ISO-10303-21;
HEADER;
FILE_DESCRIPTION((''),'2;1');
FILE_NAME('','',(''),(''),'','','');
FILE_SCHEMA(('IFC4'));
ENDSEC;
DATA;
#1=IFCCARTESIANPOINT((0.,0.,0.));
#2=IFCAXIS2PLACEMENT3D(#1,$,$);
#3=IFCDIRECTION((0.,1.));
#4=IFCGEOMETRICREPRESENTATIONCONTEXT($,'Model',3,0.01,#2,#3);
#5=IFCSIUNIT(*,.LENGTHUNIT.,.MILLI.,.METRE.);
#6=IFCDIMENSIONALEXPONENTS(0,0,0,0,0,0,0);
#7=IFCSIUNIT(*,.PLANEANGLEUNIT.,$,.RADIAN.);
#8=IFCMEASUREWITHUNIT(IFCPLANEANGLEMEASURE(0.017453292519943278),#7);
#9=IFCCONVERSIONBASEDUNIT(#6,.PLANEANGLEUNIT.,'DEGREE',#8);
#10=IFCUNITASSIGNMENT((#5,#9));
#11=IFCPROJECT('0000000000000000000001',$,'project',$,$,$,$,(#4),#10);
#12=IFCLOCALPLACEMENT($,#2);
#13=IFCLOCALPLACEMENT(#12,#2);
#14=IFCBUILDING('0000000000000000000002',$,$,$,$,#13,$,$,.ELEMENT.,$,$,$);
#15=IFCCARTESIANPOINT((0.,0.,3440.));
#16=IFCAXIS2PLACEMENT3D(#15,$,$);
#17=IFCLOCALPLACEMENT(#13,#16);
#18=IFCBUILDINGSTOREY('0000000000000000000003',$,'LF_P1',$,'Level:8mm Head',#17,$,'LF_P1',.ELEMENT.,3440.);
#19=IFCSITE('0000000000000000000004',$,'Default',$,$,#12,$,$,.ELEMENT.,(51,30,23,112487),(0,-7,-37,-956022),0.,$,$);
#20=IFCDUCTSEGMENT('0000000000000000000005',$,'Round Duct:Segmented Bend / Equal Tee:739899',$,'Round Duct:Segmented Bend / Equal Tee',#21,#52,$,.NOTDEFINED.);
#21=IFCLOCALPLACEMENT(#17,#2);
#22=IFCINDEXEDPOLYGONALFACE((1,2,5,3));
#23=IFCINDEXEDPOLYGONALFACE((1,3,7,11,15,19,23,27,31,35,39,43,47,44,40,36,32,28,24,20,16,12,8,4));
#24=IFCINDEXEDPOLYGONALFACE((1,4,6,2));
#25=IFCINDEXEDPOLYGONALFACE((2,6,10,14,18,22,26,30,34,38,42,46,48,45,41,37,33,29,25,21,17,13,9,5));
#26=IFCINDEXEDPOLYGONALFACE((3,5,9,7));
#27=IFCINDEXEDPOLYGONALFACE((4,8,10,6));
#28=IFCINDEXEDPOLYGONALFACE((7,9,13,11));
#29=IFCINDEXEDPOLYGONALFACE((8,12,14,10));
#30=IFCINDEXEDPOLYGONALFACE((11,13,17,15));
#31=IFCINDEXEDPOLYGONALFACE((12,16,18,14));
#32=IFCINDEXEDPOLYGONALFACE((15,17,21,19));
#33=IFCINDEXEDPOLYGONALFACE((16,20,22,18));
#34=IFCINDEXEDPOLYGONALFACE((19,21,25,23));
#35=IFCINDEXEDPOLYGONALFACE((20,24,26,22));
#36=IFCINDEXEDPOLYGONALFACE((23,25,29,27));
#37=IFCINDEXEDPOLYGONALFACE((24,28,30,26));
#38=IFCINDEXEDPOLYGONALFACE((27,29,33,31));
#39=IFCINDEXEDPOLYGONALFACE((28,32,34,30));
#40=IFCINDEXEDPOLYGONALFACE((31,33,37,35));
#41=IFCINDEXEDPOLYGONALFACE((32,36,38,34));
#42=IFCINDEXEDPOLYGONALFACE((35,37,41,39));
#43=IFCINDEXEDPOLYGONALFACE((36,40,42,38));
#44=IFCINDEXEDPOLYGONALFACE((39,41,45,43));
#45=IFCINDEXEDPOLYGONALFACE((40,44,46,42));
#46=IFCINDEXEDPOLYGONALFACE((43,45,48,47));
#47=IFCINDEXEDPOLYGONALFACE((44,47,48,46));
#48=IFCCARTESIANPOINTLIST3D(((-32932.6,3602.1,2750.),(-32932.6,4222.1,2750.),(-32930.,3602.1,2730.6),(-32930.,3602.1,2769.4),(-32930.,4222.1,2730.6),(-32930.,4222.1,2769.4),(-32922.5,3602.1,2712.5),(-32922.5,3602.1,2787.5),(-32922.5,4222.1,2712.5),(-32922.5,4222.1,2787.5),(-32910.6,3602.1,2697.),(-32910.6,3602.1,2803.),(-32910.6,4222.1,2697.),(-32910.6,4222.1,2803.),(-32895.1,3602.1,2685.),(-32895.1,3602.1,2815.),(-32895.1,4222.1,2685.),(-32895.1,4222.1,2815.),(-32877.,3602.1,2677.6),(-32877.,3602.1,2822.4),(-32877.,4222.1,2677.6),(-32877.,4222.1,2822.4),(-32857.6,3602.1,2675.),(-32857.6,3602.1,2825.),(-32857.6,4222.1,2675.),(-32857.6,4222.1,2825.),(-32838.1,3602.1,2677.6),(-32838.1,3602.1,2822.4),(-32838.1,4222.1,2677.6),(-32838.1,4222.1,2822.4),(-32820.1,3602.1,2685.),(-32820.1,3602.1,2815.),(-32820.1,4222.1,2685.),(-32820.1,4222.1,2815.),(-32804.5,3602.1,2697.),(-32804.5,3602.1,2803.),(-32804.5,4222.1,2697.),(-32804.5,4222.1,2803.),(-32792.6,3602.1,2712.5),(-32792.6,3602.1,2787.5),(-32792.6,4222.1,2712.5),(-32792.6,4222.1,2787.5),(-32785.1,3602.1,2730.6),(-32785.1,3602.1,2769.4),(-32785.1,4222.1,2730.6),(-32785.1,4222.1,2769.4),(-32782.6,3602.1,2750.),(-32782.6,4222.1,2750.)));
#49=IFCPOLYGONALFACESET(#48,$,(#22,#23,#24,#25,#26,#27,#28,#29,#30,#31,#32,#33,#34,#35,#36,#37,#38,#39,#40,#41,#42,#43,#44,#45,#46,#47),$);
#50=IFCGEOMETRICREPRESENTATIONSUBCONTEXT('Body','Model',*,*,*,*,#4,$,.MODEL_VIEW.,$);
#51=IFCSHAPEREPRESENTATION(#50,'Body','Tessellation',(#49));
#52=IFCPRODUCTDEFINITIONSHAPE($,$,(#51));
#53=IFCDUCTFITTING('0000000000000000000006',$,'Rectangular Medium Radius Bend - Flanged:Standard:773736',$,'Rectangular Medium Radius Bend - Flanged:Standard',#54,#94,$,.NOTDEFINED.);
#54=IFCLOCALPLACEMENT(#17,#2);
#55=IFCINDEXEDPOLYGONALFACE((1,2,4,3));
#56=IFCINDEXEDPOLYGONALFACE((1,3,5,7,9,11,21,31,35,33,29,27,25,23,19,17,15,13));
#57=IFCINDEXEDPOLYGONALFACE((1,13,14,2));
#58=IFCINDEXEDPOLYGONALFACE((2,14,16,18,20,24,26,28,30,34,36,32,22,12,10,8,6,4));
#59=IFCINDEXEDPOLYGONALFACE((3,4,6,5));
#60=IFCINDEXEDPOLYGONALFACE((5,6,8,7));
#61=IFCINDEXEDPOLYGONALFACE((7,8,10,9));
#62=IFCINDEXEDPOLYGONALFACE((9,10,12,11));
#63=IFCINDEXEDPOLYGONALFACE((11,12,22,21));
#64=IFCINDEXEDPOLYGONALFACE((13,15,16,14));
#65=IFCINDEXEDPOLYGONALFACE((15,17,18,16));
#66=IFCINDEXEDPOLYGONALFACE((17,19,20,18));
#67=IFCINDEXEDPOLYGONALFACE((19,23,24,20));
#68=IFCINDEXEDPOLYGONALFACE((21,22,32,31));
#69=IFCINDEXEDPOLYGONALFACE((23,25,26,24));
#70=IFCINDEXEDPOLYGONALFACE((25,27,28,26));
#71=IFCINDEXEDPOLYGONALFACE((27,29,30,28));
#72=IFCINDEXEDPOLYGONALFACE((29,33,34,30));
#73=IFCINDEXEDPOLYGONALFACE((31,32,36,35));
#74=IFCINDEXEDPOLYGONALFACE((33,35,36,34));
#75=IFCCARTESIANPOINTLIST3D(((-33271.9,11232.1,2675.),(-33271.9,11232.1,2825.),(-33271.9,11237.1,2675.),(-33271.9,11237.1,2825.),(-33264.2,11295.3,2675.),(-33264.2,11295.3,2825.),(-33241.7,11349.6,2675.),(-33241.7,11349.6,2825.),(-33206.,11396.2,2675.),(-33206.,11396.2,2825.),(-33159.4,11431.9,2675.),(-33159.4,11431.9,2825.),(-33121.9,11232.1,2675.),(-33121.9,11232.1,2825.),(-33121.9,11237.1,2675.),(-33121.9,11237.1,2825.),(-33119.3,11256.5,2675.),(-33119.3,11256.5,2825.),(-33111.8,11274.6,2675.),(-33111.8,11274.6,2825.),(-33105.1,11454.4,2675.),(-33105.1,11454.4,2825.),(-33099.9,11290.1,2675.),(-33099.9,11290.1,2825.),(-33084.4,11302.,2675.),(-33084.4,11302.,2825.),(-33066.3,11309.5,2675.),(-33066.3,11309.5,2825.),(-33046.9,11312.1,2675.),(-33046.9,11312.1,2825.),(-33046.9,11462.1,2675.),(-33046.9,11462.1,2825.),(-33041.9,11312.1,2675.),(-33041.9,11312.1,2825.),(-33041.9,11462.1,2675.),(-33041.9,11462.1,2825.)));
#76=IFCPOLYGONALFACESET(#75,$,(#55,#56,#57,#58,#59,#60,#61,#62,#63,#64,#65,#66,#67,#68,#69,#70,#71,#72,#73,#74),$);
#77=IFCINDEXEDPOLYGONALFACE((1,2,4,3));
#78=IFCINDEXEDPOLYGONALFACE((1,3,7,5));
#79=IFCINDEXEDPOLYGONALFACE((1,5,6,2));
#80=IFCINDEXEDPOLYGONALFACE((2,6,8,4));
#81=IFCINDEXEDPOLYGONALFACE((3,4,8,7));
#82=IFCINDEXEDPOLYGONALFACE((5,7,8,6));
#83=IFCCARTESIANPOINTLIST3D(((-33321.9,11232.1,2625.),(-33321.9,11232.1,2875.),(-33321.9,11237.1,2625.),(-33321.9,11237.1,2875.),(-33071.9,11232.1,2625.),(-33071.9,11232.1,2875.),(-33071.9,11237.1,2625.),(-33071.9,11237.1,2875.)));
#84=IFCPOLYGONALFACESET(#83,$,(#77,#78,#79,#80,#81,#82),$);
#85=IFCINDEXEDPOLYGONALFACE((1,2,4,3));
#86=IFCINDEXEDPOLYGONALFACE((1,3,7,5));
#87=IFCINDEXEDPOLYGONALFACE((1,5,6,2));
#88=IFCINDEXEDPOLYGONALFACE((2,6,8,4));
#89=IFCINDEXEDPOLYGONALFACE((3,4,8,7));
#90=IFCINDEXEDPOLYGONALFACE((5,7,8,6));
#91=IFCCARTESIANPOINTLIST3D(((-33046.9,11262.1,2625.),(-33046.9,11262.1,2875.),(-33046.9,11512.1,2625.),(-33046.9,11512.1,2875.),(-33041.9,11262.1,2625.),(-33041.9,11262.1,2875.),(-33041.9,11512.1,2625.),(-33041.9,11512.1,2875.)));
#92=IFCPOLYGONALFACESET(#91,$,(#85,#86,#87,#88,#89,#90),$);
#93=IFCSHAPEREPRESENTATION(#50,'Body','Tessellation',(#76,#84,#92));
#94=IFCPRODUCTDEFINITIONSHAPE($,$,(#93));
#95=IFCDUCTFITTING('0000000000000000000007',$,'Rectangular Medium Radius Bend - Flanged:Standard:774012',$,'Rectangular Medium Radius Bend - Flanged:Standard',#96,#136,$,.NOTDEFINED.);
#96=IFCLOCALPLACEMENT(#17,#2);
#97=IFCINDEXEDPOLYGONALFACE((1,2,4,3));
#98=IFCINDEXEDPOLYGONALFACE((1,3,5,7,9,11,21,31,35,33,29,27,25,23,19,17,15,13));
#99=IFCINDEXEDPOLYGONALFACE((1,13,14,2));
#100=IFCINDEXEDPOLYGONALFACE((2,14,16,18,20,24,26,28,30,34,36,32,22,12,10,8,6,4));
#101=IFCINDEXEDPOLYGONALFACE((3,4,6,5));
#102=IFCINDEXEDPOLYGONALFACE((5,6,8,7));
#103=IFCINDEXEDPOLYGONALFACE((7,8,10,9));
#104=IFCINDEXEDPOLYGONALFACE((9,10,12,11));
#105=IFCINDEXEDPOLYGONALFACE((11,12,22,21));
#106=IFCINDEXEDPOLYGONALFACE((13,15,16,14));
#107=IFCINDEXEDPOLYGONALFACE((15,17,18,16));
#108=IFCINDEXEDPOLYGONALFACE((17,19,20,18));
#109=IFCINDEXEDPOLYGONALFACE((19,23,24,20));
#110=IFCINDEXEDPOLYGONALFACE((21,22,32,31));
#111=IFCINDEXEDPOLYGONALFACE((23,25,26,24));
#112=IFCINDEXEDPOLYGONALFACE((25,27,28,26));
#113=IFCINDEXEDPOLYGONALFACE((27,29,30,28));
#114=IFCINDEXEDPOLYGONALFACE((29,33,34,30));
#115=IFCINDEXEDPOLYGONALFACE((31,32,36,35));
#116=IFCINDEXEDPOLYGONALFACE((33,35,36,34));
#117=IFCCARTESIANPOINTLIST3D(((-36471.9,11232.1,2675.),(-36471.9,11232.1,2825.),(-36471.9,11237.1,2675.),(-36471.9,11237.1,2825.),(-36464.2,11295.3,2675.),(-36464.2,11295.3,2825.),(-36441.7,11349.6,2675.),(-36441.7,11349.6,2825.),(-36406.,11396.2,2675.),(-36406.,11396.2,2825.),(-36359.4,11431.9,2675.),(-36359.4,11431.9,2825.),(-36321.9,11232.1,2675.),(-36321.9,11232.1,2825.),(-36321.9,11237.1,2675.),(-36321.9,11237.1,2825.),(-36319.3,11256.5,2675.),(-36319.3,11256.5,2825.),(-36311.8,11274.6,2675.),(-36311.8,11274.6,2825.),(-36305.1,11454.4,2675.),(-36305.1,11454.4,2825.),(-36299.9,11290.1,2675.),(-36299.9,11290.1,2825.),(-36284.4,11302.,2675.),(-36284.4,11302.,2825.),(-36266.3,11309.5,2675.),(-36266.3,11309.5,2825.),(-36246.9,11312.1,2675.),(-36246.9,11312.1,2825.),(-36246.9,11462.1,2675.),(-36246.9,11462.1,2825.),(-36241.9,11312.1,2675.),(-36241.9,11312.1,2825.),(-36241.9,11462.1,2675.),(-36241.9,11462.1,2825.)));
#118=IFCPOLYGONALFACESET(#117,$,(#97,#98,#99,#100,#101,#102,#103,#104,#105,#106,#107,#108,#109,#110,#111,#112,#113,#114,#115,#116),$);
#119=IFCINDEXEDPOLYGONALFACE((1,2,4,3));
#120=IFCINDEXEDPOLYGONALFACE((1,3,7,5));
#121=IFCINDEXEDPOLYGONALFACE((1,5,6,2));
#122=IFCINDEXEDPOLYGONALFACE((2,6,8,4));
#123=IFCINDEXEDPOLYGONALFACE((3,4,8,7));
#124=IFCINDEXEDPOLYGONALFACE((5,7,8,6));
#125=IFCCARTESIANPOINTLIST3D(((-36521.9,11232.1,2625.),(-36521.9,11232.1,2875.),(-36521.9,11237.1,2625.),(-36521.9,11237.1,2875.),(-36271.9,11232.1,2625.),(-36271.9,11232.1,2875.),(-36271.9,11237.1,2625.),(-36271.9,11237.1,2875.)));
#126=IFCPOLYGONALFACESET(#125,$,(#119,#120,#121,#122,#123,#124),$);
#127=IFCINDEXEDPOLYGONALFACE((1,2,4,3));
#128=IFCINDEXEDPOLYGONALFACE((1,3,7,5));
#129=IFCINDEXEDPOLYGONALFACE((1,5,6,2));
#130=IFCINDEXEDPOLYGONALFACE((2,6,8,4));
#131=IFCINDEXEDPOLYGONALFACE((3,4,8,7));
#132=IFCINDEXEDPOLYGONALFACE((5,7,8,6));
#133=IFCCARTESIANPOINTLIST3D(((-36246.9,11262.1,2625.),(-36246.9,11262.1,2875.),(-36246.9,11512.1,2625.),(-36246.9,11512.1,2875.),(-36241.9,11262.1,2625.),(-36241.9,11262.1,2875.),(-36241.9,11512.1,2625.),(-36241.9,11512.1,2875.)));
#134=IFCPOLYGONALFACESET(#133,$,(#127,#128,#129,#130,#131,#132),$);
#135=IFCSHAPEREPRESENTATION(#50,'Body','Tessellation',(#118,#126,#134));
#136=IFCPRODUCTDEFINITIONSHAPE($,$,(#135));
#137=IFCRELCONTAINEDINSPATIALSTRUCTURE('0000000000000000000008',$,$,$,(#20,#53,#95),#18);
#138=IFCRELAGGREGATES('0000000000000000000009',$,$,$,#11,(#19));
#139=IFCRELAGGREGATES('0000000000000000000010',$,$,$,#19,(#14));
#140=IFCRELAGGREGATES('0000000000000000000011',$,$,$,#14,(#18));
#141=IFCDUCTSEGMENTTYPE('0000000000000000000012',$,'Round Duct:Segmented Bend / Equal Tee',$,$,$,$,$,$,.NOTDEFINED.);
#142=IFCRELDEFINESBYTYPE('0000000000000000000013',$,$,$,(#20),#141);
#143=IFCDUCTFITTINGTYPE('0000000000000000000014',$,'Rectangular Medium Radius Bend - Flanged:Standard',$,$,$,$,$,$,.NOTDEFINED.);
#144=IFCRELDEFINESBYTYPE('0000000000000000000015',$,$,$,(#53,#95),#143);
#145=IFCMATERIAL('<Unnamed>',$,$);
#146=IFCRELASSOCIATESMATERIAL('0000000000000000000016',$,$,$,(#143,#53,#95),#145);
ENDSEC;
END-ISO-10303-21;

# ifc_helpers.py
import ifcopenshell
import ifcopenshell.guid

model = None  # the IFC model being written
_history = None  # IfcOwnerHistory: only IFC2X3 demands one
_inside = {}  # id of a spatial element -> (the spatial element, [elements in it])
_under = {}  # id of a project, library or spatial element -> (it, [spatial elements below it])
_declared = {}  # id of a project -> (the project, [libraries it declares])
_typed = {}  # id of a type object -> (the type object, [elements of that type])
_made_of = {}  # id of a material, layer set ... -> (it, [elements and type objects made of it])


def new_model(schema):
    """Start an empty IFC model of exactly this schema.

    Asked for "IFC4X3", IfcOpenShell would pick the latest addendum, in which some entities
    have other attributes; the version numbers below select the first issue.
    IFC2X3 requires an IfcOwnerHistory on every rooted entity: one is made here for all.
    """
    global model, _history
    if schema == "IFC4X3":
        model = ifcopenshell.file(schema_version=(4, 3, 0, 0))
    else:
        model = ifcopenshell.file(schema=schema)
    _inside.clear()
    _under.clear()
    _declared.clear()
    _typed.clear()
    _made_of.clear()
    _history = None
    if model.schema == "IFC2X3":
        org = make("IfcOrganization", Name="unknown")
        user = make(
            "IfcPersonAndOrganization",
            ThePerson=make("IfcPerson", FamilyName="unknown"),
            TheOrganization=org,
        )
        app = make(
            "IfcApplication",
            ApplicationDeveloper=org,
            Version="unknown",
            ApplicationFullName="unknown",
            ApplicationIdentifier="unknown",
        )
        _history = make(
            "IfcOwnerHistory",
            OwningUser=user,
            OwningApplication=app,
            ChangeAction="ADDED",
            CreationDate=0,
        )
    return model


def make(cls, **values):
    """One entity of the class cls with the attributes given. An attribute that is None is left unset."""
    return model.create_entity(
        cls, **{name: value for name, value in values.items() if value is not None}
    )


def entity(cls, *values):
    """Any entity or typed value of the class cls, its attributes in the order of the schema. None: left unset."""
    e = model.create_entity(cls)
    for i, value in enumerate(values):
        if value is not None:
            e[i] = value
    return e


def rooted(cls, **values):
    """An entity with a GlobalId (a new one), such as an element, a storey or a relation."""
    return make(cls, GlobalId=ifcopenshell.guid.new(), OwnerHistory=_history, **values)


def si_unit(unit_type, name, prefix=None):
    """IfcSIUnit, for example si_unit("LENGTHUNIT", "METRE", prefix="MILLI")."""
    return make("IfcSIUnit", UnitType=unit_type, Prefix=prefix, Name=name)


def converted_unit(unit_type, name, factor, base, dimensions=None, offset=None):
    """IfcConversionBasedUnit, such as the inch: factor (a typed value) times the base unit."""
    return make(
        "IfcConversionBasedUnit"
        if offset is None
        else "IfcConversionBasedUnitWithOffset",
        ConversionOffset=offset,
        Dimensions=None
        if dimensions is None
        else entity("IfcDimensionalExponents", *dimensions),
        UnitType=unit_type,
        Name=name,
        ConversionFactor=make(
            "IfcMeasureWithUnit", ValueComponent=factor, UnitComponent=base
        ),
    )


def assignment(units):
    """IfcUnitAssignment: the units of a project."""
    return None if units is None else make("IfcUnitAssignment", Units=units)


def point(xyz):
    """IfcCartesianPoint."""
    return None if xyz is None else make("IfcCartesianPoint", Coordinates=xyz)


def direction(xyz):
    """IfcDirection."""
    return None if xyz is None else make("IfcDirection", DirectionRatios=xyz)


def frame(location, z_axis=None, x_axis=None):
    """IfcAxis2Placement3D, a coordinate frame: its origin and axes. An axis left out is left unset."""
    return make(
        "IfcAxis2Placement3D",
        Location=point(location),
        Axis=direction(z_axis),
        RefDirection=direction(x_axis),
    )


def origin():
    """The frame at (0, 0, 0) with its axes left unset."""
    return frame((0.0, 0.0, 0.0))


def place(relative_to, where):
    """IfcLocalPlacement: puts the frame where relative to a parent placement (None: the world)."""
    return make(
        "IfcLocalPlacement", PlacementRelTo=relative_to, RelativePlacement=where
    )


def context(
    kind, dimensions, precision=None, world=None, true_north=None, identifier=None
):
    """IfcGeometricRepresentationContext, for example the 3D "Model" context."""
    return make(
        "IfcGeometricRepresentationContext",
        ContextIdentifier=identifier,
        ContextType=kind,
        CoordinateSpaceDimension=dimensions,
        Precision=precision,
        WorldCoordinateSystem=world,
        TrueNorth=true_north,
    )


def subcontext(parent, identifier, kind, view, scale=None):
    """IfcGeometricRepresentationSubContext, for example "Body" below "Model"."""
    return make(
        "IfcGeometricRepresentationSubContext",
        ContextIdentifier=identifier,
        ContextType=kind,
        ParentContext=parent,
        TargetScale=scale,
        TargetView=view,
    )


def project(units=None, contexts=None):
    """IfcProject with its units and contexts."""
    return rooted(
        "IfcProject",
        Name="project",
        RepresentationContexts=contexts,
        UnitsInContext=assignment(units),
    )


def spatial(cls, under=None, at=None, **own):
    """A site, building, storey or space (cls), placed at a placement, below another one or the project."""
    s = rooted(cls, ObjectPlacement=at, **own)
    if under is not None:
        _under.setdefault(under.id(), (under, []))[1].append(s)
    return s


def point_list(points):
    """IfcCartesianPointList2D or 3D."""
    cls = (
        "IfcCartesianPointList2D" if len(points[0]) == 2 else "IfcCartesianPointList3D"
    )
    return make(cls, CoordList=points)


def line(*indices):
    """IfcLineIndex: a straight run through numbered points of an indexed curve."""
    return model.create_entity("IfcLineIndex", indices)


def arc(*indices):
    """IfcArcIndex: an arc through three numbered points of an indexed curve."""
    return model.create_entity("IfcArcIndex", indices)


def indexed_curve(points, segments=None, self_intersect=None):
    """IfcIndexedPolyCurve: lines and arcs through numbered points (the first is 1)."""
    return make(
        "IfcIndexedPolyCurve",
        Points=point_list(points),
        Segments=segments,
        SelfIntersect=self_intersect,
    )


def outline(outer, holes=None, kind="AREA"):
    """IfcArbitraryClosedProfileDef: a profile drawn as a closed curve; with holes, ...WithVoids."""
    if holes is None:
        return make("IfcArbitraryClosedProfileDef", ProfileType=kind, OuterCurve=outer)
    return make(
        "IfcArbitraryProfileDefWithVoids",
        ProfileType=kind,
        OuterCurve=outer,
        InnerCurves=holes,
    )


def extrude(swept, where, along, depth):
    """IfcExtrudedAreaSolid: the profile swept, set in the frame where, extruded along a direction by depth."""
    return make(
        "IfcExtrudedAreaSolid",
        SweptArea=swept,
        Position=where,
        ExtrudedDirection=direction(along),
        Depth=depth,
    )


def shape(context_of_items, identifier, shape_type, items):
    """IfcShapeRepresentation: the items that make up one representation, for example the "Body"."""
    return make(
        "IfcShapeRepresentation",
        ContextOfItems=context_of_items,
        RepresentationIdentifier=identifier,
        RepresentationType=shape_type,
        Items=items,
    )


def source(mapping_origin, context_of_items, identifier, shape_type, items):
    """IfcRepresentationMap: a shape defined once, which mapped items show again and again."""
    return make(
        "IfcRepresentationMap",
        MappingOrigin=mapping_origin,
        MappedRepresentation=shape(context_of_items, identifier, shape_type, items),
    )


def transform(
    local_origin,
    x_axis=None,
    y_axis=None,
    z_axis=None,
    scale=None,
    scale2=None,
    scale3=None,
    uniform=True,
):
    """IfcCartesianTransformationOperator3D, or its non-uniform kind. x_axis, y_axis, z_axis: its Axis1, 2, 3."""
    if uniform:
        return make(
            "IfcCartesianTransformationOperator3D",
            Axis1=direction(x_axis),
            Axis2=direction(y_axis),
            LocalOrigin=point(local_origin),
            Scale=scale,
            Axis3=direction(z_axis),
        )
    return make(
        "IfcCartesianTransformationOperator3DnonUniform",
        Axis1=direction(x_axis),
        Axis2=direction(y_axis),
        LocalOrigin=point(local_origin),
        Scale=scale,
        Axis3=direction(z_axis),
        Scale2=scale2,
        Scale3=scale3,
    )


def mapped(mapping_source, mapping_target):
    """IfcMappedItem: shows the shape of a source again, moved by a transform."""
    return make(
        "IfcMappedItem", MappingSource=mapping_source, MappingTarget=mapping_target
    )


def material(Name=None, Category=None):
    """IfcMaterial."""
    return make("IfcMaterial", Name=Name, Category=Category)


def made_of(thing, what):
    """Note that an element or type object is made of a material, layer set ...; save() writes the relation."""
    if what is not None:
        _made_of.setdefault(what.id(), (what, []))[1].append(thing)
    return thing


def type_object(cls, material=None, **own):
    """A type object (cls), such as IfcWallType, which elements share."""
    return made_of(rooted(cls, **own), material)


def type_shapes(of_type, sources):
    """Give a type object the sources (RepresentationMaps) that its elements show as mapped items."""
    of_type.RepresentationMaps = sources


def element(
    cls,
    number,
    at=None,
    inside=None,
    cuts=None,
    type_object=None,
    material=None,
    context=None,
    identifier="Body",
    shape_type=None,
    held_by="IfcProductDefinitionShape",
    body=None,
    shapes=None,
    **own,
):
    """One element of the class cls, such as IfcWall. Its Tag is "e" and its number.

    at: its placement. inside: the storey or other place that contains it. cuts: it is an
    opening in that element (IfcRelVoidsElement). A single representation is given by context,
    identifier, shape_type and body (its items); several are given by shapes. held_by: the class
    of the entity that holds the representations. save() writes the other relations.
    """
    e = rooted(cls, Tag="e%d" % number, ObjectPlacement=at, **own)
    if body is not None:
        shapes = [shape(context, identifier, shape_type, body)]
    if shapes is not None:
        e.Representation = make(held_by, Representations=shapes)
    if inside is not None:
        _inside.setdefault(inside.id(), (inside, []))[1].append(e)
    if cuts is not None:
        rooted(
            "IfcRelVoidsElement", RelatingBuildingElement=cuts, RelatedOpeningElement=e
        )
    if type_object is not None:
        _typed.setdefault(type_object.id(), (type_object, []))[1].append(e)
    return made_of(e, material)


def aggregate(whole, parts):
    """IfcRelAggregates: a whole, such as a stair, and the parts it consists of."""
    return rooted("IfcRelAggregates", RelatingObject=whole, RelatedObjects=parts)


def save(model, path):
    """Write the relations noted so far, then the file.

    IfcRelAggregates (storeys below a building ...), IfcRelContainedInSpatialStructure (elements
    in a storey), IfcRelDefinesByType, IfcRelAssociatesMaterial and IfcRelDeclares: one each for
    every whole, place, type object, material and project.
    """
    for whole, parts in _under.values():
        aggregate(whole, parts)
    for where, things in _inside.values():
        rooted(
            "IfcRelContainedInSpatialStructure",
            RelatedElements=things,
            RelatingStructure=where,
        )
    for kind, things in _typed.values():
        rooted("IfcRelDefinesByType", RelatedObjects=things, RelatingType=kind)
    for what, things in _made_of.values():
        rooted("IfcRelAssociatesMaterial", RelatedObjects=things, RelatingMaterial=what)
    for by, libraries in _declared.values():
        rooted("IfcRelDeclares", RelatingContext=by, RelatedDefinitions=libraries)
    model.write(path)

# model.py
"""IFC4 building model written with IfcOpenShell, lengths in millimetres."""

from ifc_helpers import new_model, entity, si_unit, converted_unit, direction, frame, origin, place, context, subcontext, project, spatial, line, arc, indexed_curve, outline, extrude, source, transform, mapped, material, type_object, type_shapes, element, save


model = new_model("IFC4")

# Units and contexts
model_context = context("Model", 3, precision=0.01, world=origin(), true_north=direction((0.0, 1.0)))
body_context = subcontext(model_context, "Body", "Model", "MODEL_VIEW")
ifc_project = project(units=[si_unit("LENGTHUNIT", "METRE", prefix="MILLI"), converted_unit("PLANEANGLEUNIT", "DEGREE", entity("IfcPlaneAngleMeasure", 0.017453292519943278), si_unit("PLANEANGLEUNIT", "RADIAN"), dimensions=[0, 0, 0, 0, 0, 0, 0])], contexts=[model_context])

# Site, building, storey
site_placement = place(None, origin())
site = spatial("IfcSite", under=ifc_project, at=site_placement, Name="Default", CompositionType="ELEMENT", RefLatitude=(51, 30, 23, 112487), RefLongitude=(0, -7, -37, -956022), RefElevation=0.0)
building_placement = place(site_placement, origin())
building = spatial("IfcBuilding", under=site, at=building_placement, CompositionType="ELEMENT")
storey_placement = place(building_placement, frame((0.0, 0.0, 3440.0)))
storey = spatial("IfcBuildingStorey", under=building, at=storey_placement, Name="LF_P1", ObjectType="Level:8mm Head", LongName="LF_P1", CompositionType="ELEMENT", Elevation=3440.0)

# Duct segment
duct_segment_type_1 = type_object("IfcDuctSegmentType", Name="Round Duct:Segmented Bend / Equal Tee", PredefinedType="NOTDEFINED")
duct_segment_1_placement = place(storey_placement, origin())
element("IfcDuctSegment", 1, at=duct_segment_1_placement, inside=storey, type_object=duct_segment_type_1, Name="Round Duct:Segmented Bend / Equal Tee:739899", ObjectType="Round Duct:Segmented Bend / Equal Tee", PredefinedType="NOTDEFINED", context=body_context, shape_type="SweptSolid", body=[
    extrude(outline(indexed_curve([(75.0, 0.0), (53.0, 53.0), (0.0, 75.0), (-53.0, 53.0), (-75.0, 0.0), (-53.0, -53.0), (0.0, -75.0), (53.0, -53.0)], segments=[arc(1, 2, 3), arc(3, 4, 5), arc(5, 6, 7), arc(7, 8, 1)], self_intersect=False)), frame((-32857.6, 3602.1, 2750.0), z_axis=(0.0, 1.0, 0.0), x_axis=(-1.0, 0.0, 0.0)), (0.0, 0.0, 1.0), 620.0),
])

# Duct fittings
ifc_material = material(Name="<Unnamed>")
duct_fitting_type = type_object("IfcDuctFittingType", Name="Rectangular Medium Radius Bend - Flanged:Standard", PredefinedType="NOTDEFINED", material=ifc_material)
shared_shape_1 = source(origin(), body_context, "Body", "SweptSolid", [
    extrude(outline(indexed_curve([(-78.8, -151.2), (-73.7, -151.2), (85.3, -85.3), (151.3, 73.7), (151.3, 78.7), (1.3, 78.7), (1.3, 73.8), (-20.7, 20.7), (-73.7, -1.2), (-78.8, -1.2)], segments=[line(1, 2), arc(2, 3, 4), line(4, 5, 6, 7), arc(7, 8, 9), line(9, 10, 1)], self_intersect=False)), frame((-76.2, 76.2, -75.0)), (0.0, 0.0, 1.0), 150.0),
    extrude(outline(indexed_curve([(-2.5, -125.0), (2.5, -125.0), (2.5, 125.0), (-2.5, 125.0), (-2.5, -125.0)], self_intersect=False)), frame((0.0, 152.5, -125.0), z_axis=(0.0, 0.0, 1.0), x_axis=(0.0, 1.0, 0.0)), (0.0, 0.0, 1.0), 250.0),
    extrude(outline(indexed_curve([(-2.5, -125.0), (2.5, -125.0), (2.5, 125.0), (-2.5, 125.0), (-2.5, -125.0)], self_intersect=False)), frame((-152.5, 0.0, -125.0)), (0.0, 0.0, 1.0), 250.0),
])
type_shapes(duct_fitting_type, [shared_shape_1])
for number, where, z_axis, x_axis, name in (
    (2, (-33196.9, 11387.1, 2750.0), (0.0, 0.0, 1.0), (-1.0, 0.0, 0.0), "Rectangular Medium Radius Bend - Flanged:Standard:773736"),
    (3, (-36396.9, 11387.1, 2750.0), (0.0, 0.0, 1.0), (-1.0, 0.0, 0.0), "Rectangular Medium Radius Bend - Flanged:Standard:774012"),
):
    element("IfcDuctFitting", number, at=place(storey_placement, frame(where, z_axis=z_axis, x_axis=x_axis)), inside=storey, type_object=duct_fitting_type, material=ifc_material, Name=name, ObjectType="Rectangular Medium Radius Bend - Flanged:Standard", PredefinedType="NOTDEFINED", context=body_context, shape_type="MappedRepresentation", body=[
        mapped(shared_shape_1, transform((0.0, 0.0, 0.0), scale=1.0)),
    ])

save(model, "model.ifc")
